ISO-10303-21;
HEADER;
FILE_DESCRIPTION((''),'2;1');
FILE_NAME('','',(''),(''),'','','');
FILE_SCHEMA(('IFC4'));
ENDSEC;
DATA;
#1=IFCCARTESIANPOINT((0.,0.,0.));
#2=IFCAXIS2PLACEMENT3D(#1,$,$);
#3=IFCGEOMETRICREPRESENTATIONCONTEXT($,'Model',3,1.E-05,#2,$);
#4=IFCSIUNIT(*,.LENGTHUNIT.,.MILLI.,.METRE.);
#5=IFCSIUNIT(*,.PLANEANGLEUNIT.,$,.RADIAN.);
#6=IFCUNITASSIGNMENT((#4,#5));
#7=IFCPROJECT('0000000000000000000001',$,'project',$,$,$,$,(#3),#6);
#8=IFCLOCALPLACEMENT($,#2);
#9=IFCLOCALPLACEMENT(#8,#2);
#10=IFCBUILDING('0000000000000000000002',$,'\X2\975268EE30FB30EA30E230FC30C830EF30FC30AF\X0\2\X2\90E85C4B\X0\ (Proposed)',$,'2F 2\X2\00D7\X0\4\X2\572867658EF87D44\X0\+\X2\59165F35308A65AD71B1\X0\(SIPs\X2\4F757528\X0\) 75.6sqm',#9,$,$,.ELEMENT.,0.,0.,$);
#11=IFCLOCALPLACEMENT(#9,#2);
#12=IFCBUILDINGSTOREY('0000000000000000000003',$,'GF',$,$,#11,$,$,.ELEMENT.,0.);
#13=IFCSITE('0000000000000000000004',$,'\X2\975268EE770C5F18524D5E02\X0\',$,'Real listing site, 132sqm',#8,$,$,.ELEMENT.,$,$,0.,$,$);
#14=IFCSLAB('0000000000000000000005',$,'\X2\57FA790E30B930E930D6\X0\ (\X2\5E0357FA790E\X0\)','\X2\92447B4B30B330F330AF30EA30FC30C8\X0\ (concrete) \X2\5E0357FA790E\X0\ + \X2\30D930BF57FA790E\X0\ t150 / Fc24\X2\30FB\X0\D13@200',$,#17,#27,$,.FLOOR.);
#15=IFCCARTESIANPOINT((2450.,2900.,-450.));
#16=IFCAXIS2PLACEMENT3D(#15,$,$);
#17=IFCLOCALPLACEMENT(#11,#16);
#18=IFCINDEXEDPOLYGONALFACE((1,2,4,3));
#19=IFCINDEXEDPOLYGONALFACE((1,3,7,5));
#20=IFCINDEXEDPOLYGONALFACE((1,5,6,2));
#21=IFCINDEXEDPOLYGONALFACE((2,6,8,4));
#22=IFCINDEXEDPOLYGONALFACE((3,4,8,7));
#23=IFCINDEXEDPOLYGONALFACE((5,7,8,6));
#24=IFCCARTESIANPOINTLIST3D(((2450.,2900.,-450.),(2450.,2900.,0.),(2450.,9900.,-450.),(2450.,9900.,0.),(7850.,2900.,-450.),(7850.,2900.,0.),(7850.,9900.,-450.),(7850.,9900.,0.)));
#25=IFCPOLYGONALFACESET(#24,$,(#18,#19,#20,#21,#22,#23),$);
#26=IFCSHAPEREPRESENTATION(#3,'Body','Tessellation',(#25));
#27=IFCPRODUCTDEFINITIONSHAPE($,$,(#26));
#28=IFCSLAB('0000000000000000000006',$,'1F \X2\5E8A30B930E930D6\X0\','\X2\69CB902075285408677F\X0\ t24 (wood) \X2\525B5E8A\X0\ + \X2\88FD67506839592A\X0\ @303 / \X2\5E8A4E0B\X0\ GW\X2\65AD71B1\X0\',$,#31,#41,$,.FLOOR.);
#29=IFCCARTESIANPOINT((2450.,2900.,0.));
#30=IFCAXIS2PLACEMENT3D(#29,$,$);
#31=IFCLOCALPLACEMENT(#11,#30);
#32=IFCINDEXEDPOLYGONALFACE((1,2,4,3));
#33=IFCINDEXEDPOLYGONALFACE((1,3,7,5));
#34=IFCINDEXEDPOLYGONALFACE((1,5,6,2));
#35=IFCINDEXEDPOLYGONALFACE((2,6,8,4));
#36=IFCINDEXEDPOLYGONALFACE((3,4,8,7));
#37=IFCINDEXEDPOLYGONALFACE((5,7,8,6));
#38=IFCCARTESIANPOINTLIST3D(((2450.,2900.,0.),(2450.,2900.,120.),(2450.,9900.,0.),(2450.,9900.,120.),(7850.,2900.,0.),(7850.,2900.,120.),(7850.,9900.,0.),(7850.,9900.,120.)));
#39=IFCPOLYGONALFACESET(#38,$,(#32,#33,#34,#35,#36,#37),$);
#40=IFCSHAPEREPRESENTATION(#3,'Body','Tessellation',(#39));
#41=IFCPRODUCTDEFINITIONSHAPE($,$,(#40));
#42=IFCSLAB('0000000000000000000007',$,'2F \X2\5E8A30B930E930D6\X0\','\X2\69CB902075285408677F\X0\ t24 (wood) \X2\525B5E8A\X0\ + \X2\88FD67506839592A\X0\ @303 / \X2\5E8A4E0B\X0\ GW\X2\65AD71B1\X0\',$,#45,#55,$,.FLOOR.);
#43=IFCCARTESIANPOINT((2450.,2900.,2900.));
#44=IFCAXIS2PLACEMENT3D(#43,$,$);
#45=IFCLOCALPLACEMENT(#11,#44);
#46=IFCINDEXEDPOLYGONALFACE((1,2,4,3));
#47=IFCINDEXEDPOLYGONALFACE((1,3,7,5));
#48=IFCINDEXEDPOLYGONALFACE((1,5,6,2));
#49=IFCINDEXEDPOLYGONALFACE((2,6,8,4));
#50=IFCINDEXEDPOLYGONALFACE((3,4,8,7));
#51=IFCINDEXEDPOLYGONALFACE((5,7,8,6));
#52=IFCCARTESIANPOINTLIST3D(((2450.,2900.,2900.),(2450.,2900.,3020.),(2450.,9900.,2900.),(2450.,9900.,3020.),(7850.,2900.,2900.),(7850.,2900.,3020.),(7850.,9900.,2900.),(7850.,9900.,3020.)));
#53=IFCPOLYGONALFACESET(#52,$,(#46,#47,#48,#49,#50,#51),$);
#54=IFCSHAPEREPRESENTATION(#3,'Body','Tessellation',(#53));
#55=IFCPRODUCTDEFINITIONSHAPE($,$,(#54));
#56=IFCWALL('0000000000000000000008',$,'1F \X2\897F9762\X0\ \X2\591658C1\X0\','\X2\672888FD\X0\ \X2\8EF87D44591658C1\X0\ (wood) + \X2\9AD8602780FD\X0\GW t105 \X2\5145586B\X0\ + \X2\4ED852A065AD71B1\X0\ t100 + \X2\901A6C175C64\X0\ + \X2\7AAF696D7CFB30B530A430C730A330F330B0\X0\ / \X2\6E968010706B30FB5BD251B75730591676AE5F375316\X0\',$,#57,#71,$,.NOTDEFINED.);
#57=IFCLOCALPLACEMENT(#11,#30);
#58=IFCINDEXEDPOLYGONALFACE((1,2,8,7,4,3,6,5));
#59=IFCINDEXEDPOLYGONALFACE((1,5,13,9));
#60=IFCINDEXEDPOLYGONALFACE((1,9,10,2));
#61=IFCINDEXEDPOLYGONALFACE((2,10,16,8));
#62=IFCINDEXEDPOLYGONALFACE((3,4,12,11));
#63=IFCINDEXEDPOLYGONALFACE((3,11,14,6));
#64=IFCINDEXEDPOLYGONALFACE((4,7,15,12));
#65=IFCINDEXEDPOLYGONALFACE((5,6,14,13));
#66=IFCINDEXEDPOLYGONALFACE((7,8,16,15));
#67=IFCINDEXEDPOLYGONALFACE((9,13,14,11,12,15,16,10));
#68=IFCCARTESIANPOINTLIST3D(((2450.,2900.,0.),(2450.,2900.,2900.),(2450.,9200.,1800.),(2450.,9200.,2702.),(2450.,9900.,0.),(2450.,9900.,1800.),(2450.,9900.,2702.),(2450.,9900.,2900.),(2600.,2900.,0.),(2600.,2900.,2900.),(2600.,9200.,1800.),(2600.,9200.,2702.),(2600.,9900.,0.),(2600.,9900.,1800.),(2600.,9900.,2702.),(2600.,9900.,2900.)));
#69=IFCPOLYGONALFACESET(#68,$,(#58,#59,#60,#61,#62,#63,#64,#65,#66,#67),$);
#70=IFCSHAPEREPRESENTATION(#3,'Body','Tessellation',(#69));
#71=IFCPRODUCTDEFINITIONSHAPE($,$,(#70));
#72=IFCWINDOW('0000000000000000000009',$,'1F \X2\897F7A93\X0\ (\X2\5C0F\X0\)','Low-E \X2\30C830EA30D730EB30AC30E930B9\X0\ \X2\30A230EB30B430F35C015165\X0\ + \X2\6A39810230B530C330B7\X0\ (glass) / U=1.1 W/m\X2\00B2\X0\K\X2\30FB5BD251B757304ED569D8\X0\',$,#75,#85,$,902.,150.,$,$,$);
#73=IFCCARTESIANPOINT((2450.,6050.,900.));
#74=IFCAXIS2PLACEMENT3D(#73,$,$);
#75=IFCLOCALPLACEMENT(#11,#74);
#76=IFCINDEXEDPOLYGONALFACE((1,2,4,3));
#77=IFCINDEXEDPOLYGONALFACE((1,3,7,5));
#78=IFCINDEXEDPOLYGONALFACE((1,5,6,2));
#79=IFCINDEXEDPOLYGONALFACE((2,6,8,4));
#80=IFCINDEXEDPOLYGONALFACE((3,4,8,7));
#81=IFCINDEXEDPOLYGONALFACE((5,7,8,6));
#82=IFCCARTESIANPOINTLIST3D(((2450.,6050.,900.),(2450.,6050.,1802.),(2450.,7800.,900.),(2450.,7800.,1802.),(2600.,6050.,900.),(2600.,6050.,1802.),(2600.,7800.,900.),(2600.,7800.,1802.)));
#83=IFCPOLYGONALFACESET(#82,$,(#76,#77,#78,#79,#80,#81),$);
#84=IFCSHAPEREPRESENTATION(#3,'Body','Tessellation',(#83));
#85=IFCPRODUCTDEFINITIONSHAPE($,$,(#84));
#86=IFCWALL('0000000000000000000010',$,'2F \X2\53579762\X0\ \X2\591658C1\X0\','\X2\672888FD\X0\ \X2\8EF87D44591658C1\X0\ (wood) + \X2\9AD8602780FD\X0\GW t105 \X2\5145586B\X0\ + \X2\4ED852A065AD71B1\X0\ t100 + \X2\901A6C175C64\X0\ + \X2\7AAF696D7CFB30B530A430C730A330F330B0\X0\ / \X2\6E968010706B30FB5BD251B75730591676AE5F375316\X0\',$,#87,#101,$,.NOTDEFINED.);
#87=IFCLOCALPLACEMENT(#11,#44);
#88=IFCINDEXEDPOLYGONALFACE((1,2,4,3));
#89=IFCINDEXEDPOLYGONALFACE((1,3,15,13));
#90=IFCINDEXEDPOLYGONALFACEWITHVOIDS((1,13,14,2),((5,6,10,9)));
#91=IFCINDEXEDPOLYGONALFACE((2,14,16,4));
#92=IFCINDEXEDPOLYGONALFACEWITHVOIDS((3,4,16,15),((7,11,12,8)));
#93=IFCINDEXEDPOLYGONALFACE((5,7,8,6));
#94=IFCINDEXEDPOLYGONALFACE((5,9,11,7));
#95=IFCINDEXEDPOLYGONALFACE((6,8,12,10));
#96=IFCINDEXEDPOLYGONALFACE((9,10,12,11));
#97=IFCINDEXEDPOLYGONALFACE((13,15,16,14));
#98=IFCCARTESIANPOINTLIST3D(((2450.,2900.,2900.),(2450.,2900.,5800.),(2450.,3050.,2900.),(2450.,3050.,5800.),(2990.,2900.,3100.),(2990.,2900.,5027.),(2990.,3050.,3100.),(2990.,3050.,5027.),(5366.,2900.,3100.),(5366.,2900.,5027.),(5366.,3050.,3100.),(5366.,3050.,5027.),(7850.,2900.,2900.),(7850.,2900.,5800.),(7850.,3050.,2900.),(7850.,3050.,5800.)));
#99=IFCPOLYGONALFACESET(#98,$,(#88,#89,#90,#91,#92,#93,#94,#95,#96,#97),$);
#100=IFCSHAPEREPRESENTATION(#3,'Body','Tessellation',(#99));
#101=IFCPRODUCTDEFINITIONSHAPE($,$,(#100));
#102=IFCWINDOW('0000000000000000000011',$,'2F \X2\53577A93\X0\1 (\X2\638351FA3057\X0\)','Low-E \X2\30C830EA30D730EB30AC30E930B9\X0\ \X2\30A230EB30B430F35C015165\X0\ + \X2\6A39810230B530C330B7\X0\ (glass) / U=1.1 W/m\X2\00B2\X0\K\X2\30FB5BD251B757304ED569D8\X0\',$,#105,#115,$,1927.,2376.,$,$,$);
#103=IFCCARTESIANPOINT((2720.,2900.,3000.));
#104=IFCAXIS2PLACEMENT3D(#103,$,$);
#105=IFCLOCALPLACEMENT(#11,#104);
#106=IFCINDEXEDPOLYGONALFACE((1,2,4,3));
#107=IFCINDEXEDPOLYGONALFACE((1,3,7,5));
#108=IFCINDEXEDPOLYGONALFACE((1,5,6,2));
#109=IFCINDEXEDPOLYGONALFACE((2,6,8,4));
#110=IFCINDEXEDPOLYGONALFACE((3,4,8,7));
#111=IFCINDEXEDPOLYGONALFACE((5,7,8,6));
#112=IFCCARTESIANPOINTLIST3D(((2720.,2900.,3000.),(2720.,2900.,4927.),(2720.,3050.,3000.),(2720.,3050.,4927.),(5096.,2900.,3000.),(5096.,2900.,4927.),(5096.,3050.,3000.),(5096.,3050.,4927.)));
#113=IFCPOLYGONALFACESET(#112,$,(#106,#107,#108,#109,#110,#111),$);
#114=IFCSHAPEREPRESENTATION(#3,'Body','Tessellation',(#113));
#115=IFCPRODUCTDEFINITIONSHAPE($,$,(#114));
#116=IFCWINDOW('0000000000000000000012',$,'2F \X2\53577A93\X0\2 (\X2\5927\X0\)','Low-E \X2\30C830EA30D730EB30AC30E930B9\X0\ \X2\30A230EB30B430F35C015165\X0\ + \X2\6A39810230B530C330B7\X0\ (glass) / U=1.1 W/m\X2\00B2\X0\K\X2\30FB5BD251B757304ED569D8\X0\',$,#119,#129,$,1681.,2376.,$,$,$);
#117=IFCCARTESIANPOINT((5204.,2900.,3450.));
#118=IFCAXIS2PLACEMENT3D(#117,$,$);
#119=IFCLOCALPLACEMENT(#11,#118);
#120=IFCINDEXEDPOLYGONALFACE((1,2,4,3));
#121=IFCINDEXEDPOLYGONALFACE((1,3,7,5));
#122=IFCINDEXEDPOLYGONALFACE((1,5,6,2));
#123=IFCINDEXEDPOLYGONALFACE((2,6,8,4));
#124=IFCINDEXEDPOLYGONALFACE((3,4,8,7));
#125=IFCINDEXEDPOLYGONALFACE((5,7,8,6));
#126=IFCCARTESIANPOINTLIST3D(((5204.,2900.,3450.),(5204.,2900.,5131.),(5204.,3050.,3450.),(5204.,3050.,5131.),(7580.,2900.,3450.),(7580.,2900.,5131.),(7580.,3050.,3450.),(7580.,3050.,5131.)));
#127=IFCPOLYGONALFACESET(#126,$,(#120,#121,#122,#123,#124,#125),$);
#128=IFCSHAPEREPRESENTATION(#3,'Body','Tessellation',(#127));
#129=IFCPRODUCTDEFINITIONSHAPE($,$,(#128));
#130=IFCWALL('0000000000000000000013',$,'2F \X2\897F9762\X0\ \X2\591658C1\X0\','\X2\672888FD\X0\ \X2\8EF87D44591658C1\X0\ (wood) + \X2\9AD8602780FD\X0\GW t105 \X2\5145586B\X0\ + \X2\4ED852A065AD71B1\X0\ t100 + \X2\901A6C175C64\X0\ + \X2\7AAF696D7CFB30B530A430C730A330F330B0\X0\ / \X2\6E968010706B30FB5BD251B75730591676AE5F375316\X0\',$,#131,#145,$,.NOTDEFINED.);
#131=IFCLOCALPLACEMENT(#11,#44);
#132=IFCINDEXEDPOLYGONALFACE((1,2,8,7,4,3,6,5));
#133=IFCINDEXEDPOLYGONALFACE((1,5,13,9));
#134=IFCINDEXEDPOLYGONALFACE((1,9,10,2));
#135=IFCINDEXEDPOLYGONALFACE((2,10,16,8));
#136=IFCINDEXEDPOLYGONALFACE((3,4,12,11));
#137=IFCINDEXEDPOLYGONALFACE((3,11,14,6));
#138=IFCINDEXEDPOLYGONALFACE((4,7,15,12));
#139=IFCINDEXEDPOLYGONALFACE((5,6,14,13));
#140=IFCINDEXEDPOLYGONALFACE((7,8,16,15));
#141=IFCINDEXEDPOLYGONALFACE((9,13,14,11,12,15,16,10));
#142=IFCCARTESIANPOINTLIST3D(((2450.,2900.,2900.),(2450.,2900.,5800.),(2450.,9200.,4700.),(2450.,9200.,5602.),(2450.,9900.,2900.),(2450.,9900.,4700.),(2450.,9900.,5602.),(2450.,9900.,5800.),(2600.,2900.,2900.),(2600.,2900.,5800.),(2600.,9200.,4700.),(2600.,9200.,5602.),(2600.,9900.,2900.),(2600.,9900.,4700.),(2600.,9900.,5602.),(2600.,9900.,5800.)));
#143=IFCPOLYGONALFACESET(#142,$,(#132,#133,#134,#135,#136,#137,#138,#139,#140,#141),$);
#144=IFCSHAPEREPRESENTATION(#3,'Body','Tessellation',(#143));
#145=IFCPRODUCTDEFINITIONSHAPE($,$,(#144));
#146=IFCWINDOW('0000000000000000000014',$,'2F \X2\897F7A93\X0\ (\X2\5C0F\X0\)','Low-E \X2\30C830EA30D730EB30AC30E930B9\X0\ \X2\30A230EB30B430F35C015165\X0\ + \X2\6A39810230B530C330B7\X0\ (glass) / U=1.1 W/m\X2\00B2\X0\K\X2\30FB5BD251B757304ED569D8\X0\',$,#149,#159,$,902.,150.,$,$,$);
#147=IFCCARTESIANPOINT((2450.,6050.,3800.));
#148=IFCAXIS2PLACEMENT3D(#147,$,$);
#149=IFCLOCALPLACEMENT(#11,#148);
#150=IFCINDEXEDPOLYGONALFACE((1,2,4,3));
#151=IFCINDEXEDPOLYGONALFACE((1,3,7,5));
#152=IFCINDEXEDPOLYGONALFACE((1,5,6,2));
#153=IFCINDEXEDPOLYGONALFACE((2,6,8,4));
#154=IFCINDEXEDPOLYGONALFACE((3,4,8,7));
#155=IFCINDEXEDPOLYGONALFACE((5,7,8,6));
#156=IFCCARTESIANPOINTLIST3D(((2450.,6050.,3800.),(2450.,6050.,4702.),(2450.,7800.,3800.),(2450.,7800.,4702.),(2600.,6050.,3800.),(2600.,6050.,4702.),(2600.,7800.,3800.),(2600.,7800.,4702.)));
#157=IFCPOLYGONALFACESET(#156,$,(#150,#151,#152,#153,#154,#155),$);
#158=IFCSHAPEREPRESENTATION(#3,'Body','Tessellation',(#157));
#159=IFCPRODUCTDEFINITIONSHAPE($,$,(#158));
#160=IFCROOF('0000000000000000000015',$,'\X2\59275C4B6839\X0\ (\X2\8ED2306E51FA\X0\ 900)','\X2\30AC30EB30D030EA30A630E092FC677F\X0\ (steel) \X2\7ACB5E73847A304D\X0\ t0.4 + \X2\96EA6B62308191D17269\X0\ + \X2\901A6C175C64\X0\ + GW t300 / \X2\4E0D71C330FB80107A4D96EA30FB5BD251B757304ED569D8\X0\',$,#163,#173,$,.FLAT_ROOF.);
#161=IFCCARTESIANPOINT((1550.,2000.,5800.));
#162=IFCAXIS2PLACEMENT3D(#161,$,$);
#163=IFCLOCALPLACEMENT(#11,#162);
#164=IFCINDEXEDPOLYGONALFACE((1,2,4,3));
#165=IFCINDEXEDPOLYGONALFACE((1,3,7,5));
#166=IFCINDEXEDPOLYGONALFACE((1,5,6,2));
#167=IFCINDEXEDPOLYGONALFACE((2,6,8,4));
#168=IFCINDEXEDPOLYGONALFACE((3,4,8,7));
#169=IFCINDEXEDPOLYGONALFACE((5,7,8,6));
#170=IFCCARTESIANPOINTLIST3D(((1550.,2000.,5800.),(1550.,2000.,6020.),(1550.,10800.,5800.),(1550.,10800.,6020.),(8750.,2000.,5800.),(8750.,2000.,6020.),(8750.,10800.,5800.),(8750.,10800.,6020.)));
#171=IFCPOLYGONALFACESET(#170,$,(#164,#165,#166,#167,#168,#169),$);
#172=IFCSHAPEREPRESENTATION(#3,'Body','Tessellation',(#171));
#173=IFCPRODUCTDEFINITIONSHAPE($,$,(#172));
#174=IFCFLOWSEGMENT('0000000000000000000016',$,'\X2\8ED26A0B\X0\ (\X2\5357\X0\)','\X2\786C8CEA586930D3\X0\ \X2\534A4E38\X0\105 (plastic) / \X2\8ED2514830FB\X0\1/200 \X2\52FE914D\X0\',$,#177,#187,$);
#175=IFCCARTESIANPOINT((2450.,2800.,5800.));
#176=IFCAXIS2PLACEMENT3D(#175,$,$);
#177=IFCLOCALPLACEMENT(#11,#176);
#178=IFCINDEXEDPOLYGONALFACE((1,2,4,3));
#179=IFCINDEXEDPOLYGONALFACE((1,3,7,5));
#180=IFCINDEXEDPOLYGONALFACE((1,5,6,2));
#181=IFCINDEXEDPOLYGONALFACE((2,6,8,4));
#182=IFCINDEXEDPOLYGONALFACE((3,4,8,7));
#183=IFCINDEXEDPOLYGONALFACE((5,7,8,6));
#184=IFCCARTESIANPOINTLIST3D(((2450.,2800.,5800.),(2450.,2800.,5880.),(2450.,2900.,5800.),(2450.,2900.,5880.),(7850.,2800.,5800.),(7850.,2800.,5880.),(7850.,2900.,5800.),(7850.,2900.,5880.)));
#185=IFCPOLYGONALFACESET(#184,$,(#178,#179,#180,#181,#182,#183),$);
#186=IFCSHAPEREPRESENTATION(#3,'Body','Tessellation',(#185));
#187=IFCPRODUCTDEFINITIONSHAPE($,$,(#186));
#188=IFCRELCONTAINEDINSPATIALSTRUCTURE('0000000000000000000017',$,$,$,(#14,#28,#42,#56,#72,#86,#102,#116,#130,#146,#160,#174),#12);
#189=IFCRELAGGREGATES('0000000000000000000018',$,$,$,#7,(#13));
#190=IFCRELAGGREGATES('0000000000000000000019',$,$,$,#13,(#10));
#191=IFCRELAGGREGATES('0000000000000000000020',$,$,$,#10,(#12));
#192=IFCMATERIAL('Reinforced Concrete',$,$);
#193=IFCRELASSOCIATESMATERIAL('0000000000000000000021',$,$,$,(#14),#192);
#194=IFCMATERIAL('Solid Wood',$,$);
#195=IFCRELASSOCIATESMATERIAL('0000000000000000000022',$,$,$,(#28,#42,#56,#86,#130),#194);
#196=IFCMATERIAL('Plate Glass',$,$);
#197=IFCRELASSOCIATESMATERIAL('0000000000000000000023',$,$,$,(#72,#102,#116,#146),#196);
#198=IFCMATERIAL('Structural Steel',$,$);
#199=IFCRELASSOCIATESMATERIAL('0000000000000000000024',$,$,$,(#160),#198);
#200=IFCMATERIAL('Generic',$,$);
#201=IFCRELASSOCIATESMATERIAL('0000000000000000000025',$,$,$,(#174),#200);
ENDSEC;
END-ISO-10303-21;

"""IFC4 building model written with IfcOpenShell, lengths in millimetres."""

from ifc_helpers import new_model, si_unit, frame, frame_2d, origin, place, context, project, spatial, rectangle, extrude, material, element, fill, save


model = new_model("IFC4")

# Units and contexts
model_context = context("Model", 3, precision=1e-05, world=origin())
ifc_project = project(units=[si_unit("LENGTHUNIT", "METRE", prefix="MILLI"), si_unit("PLANEANGLEUNIT", "RADIAN")], contexts=[model_context])

# Site, building, storey
site_placement = place(None, origin())
site = spatial("IfcSite", under=ifc_project, at=site_placement, Name="青森県弘前市", ObjectType="Real listing site, 132sqm", CompositionType="ELEMENT", RefElevation=0.0)
building_placement = place(site_placement, origin())
building = spatial("IfcBuilding", under=site, at=building_placement, Name="青森・リモートワーク2部屋 (Proposed)", ObjectType="2F 2×4在来軸組+外張り断熱(SIPs併用) 75.6sqm", CompositionType="ELEMENT", ElevationOfRefHeight=0.0, ElevationOfTerrain=0.0)
storey_placement = place(building_placement, origin())
storey = spatial("IfcBuildingStorey", under=building, at=storey_placement, Name="GF", CompositionType="ELEMENT", Elevation=0.0)

# Shared definitions
ifc_material_1 = material(Name="Solid Wood")

# Slabs
ifc_material_2 = material(Name="Reinforced Concrete")
slab_1_placement = place(storey_placement, frame((2450.0, 2900.0, -450.0)))
element("IfcSlab", 1, at=slab_1_placement, inside=storey, material=ifc_material_2, Name="基礎スラブ (布基礎)", Description="鉄筋コンクリート (concrete) 布基礎 + ベタ基礎 t150 / Fc24・D13@200", PredefinedType="FLOOR", context=model_context, shape_type="SweptSolid", body=[
    extrude(rectangle(XDim=5400.0, YDim=7000.0, at=frame_2d((2700.0, 3500.0))), frame((2450.0, 2900.0, -450.0)), (0.0, 0.0, 1.0), 450.0),
])
slab_2_placement = place(storey_placement, frame((2450.0, 2900.0, 0.0)))
element("IfcSlab", 2, at=slab_2_placement, inside=storey, material=ifc_material_1, Name="1F 床スラブ", Description="構造用合板 t24 (wood) 剛床 + 製材根太 @303 / 床下 GW断熱", PredefinedType="FLOOR", context=model_context, shape_type="SweptSolid", body=[
    extrude(rectangle(XDim=5400.0, YDim=7000.0, at=frame_2d((2700.0, 3500.0))), frame((2450.0, 2900.0, 0.0)), (0.0, 0.0, 1.0), 120.0),
])
slab_3_placement = place(storey_placement, frame((2450.0, 2900.0, 2900.0)))
element("IfcSlab", 3, at=slab_3_placement, inside=storey, material=ifc_material_1, Name="2F 床スラブ", Description="構造用合板 t24 (wood) 剛床 + 製材根太 @303 / 床下 GW断熱", PredefinedType="FLOOR", context=model_context, shape_type="SweptSolid", body=[
    extrude(rectangle(XDim=5400.0, YDim=7000.0, at=frame_2d((2700.0, 3500.0))), frame((2450.0, 2900.0, 2900.0)), (0.0, 0.0, 1.0), 120.0),
])

# Shared definitions
ifc_material_3 = material(Name="Plate Glass")

# Wall, opening, window
wall_1_placement = place(storey_placement, frame((2450.0, 2900.0, 0.0)))
wall_1 = element("IfcWall", 4, at=wall_1_placement, inside=storey, material=ifc_material_1, Name="1F 西面 外壁", Description="木製 軸組外壁 (wood) + 高性能GW t105 充填 + 付加断熱 t100 + 通気層 + 窯業系サイディング / 準耐火・寒冷地外皮強化", PredefinedType="NOTDEFINED", context=model_context, shape_type="SweptSolid", body=[
    extrude(rectangle(XDim=150.0, YDim=7000.0, at=frame_2d((75.0, 3500.0))), frame((2450.0, 2900.0, 0.0)), (0.0, 0.0, 1.0), 2900.0),
])
opening_1_placement = place(storey_placement, frame((2450.0, 6050.0, 900.0)))
opening_1 = element("IfcOpeningElement", 5, at=opening_1_placement, cuts=wall_1, PredefinedType="NOTDEFINED", context=model_context, shape_type="SweptSolid", body=[
    extrude(rectangle(XDim=150.0, YDim=1750.0, at=frame_2d((75.0, 875.0))), frame((2450.0, 6050.0, 900.0)), (0.0, 0.0, 1.0), 902.0),
])
window_1_placement = place(storey_placement, frame((2450.0, 6050.0, 900.0)))
window_1 = element("IfcWindow", 6, at=window_1_placement, inside=storey, material=ifc_material_3, Name="1F 西窓 (小)", Description="Low-E トリプルガラス アルゴン封入 + 樹脂サッシ (glass) / U=1.1 W/m²K・寒冷地仕様", OverallHeight=902.0, OverallWidth=150.0, context=model_context, shape_type="SweptSolid", body=[
    extrude(rectangle(XDim=150.0, YDim=1750.0, at=frame_2d((75.0, 875.0))), frame((2450.0, 6050.0, 900.0)), (0.0, 0.0, 1.0), 902.0),
])
fill(opening_1, window_1)

# Wall, openings, windows
wall_2_placement = place(storey_placement, frame((2450.0, 2900.0, 2900.0)))
wall_2 = element("IfcWall", 7, at=wall_2_placement, inside=storey, material=ifc_material_1, Name="2F 南面 外壁", Description="木製 軸組外壁 (wood) + 高性能GW t105 充填 + 付加断熱 t100 + 通気層 + 窯業系サイディング / 準耐火・寒冷地外皮強化", PredefinedType="NOTDEFINED", context=model_context, shape_type="SweptSolid", body=[
    extrude(rectangle(XDim=5400.0, YDim=150.0, at=frame_2d((2700.0, 75.0))), frame((2450.0, 2900.0, 2900.0)), (0.0, 0.0, 1.0), 2900.0),
])
opening_2_placement = place(storey_placement, frame((2720.0, 2900.0, 3000.0)))
opening_2 = element("IfcOpeningElement", 8, at=opening_2_placement, cuts=wall_2, PredefinedType="NOTDEFINED", context=model_context, shape_type="SweptSolid", body=[
    extrude(rectangle(XDim=2376.0, YDim=150.0, at=frame_2d((1188.0, 75.0))), frame((2720.0, 2900.0, 3000.0)), (0.0, 0.0, 1.0), 1927.0),
])
opening_3_placement = place(storey_placement, frame((5204.0, 2900.0, 3450.0)))
opening_3 = element("IfcOpeningElement", 9, at=opening_3_placement, cuts=wall_2, PredefinedType="NOTDEFINED", context=model_context, shape_type="SweptSolid", body=[
    extrude(rectangle(XDim=2376.0, YDim=150.0, at=frame_2d((1188.0, 75.0))), frame((5204.0, 2900.0, 3450.0)), (0.0, 0.0, 1.0), 1681.0),
])
window_2_placement = place(storey_placement, frame((2720.0, 2900.0, 3000.0)))
window_2 = element("IfcWindow", 10, at=window_2_placement, inside=storey, material=ifc_material_3, Name="2F 南窓1 (掃出し)", Description="Low-E トリプルガラス アルゴン封入 + 樹脂サッシ (glass) / U=1.1 W/m²K・寒冷地仕様", OverallHeight=1927.0, OverallWidth=2376.0, context=model_context, shape_type="SweptSolid", body=[
    extrude(rectangle(XDim=2376.0, YDim=150.0, at=frame_2d((1188.0, 75.0))), frame((2720.0, 2900.0, 3000.0)), (0.0, 0.0, 1.0), 1927.0),
])
fill(opening_2, window_2)
window_3_placement = place(storey_placement, frame((5204.0, 2900.0, 3450.0)))
window_3 = element("IfcWindow", 11, at=window_3_placement, inside=storey, material=ifc_material_3, Name="2F 南窓2 (大)", Description="Low-E トリプルガラス アルゴン封入 + 樹脂サッシ (glass) / U=1.1 W/m²K・寒冷地仕様", OverallHeight=1681.0, OverallWidth=2376.0, context=model_context, shape_type="SweptSolid", body=[
    extrude(rectangle(XDim=2376.0, YDim=150.0, at=frame_2d((1188.0, 75.0))), frame((5204.0, 2900.0, 3450.0)), (0.0, 0.0, 1.0), 1681.0),
])
fill(opening_3, window_3)

# Wall, opening, window
wall_3_placement = place(storey_placement, frame((2450.0, 2900.0, 2900.0)))
wall_3 = element("IfcWall", 12, at=wall_3_placement, inside=storey, material=ifc_material_1, Name="2F 西面 外壁", Description="木製 軸組外壁 (wood) + 高性能GW t105 充填 + 付加断熱 t100 + 通気層 + 窯業系サイディング / 準耐火・寒冷地外皮強化", PredefinedType="NOTDEFINED", context=model_context, shape_type="SweptSolid", body=[
    extrude(rectangle(XDim=150.0, YDim=7000.0, at=frame_2d((75.0, 3500.0))), frame((2450.0, 2900.0, 2900.0)), (0.0, 0.0, 1.0), 2900.0),
])
opening_4_placement = place(storey_placement, frame((2450.0, 6050.0, 3800.0)))
opening_4 = element("IfcOpeningElement", 13, at=opening_4_placement, cuts=wall_3, PredefinedType="NOTDEFINED", context=model_context, shape_type="SweptSolid", body=[
    extrude(rectangle(XDim=150.0, YDim=1750.0, at=frame_2d((75.0, 875.0))), frame((2450.0, 6050.0, 3800.0)), (0.0, 0.0, 1.0), 902.0),
])
window_4_placement = place(storey_placement, frame((2450.0, 6050.0, 3800.0)))
window_4 = element("IfcWindow", 14, at=window_4_placement, inside=storey, material=ifc_material_3, Name="2F 西窓 (小)", Description="Low-E トリプルガラス アルゴン封入 + 樹脂サッシ (glass) / U=1.1 W/m²K・寒冷地仕様", OverallHeight=902.0, OverallWidth=150.0, context=model_context, shape_type="SweptSolid", body=[
    extrude(rectangle(XDim=150.0, YDim=1750.0, at=frame_2d((75.0, 875.0))), frame((2450.0, 6050.0, 3800.0)), (0.0, 0.0, 1.0), 902.0),
])
fill(opening_4, window_4)

# Roof
ifc_material_4 = material(Name="Structural Steel")
roof_placement = place(storey_placement, frame((1550.0, 2000.0, 5800.0)))
element("IfcRoof", 15, at=roof_placement, inside=storey, material=ifc_material_4, Name="大屋根 (軒の出 900)", Description="ガルバリウム鋼板 (steel) 立平葺き t0.4 + 雪止め金物 + 通気層 + GW t300 / 不燃・耐積雪・寒冷地仕様", PredefinedType="FLAT_ROOF", context=model_context, shape_type="SweptSolid", body=[
    extrude(rectangle(XDim=7200.0, YDim=8800.0, at=frame_2d((3600.0, 4400.0))), frame((1550.0, 2000.0, 5800.0)), (0.0, 0.0, 1.0), 220.0),
])

# Flow segment
ifc_material_5 = material(Name="Generic")
flow_segment_1_placement = place(storey_placement, frame((2450.0, 2800.0, 5800.0)))
element("IfcFlowSegment", 16, at=flow_segment_1_placement, inside=storey, material=ifc_material_5, Name="軒樋 (南)", Description="硬質塩ビ 半丸105 (plastic) / 軒先・1/200 勾配", context=model_context, shape_type="SweptSolid", body=[
    extrude(rectangle(XDim=5400.0, YDim=100.0, at=frame_2d((2700.0, 50.0))), frame((2450.0, 2800.0, 5800.0)), (0.0, 0.0, 1.0), 80.0),
])

save(model, "model.ifc")
